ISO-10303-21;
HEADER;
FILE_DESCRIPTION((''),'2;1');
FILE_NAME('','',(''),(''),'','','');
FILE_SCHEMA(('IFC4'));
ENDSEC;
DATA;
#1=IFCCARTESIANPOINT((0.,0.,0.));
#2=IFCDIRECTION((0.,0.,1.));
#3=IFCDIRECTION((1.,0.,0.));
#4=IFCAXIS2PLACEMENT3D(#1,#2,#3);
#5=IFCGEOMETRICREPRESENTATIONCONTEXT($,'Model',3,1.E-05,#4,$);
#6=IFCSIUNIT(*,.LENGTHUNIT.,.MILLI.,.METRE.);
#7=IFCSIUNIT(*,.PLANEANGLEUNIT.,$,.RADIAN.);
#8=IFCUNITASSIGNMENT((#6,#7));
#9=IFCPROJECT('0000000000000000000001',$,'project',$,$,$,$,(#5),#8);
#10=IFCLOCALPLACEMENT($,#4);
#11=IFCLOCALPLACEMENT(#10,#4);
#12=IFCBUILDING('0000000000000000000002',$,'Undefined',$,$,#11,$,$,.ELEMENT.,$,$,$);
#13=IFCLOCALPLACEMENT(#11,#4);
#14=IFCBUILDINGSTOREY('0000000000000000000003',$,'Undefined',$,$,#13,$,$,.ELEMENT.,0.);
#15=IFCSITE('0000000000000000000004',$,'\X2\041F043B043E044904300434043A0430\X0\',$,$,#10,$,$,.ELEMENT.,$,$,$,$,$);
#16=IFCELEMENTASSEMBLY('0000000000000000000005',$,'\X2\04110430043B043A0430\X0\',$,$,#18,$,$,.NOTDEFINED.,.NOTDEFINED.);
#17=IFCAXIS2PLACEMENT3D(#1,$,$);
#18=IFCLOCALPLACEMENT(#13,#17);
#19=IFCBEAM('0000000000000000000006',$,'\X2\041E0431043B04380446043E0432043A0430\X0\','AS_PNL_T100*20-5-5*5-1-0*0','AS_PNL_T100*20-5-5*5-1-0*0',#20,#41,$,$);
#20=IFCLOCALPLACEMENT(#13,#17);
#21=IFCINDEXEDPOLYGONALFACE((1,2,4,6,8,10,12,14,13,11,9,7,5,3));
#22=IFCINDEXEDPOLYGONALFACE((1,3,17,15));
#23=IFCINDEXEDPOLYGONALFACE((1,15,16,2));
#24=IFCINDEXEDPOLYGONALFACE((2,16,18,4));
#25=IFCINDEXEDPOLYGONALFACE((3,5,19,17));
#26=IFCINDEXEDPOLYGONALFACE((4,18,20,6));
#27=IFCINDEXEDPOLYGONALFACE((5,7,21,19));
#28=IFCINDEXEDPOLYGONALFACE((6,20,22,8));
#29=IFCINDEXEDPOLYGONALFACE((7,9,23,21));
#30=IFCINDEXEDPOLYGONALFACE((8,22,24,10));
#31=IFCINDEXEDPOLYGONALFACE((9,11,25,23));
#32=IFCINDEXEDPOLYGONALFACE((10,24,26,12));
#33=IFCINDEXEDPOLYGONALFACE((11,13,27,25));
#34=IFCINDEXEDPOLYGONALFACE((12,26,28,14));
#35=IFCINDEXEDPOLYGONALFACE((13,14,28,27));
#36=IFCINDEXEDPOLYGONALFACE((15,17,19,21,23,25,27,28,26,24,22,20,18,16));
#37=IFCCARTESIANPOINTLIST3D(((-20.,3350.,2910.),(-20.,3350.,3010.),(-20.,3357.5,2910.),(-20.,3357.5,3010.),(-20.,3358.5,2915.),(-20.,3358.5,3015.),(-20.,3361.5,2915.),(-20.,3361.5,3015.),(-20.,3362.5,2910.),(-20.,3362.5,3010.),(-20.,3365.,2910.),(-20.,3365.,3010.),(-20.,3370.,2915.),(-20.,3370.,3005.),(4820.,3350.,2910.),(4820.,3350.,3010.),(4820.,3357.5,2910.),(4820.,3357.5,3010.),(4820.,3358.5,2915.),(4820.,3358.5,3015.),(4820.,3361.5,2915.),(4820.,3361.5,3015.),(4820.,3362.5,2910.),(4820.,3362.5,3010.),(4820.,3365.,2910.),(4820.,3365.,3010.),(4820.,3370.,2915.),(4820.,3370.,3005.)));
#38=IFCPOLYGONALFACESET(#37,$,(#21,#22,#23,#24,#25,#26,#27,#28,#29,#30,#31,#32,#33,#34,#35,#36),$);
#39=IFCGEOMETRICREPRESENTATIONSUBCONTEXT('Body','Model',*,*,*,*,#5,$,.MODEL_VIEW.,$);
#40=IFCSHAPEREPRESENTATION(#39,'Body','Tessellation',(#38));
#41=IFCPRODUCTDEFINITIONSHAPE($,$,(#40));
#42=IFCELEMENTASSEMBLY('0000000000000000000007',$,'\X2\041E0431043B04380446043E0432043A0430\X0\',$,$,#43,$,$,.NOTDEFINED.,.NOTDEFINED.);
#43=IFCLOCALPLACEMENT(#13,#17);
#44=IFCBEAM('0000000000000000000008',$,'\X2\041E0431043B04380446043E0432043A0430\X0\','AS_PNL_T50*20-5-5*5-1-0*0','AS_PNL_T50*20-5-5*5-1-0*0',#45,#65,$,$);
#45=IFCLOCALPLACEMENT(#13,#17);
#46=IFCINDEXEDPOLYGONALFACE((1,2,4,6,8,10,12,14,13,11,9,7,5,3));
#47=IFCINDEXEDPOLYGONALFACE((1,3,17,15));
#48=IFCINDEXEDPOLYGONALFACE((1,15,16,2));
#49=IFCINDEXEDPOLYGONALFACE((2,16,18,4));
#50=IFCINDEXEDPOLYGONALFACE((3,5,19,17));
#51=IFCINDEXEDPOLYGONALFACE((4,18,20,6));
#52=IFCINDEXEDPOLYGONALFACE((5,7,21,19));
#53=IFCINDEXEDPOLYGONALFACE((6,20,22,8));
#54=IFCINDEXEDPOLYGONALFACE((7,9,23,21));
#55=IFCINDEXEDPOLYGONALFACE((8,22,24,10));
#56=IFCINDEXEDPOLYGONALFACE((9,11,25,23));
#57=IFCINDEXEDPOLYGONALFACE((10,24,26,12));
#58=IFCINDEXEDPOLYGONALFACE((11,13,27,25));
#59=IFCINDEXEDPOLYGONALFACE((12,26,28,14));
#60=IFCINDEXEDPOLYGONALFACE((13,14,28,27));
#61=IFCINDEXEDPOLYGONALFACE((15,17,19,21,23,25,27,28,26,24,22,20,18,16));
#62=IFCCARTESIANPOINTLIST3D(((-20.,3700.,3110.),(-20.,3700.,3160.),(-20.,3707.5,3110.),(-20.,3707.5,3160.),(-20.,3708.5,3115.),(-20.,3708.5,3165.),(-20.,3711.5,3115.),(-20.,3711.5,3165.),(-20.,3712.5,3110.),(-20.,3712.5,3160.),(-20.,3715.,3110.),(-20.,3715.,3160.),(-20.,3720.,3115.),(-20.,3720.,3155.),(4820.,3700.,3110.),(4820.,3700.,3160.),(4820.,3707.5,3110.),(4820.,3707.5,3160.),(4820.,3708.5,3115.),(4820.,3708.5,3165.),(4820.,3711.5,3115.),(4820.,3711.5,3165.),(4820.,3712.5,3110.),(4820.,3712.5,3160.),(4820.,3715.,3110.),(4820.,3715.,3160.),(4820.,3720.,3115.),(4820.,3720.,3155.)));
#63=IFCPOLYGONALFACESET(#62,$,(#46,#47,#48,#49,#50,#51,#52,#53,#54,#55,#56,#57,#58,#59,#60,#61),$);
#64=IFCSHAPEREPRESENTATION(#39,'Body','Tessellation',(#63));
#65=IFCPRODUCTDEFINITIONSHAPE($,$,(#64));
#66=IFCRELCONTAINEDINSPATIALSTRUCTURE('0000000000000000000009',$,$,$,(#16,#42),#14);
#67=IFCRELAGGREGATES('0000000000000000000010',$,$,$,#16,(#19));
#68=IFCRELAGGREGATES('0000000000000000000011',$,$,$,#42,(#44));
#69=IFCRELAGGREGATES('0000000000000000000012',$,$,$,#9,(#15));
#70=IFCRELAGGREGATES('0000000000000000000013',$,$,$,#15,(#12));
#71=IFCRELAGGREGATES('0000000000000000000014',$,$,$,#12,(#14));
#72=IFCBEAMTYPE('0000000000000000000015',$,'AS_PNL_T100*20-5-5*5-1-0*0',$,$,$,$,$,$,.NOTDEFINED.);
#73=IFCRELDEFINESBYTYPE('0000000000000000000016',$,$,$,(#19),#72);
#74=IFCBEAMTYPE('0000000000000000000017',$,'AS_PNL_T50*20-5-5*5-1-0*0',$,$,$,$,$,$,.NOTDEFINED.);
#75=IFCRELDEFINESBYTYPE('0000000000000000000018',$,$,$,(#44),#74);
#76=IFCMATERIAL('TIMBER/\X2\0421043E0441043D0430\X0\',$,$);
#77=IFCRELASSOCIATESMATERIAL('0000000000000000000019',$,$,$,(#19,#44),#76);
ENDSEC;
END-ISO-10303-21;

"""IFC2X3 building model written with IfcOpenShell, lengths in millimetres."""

from ifc_helpers import new_model, si_unit, frame, origin_with_axes, place, context, subcontext, project, spatial, polyline, outline, extrude, material, type_object, element, aggregate, save


model = new_model("IFC2X3")

# Units and contexts
model_context = context("Model", 3, precision=1e-05, world=origin_with_axes())
body_context = subcontext(model_context, "Body", "Model", "MODEL_VIEW")
ifc_project = project(units=[si_unit("LENGTHUNIT", "METRE", prefix="MILLI"), si_unit("PLANEANGLEUNIT", "RADIAN")], contexts=[model_context])

# Site, building, storey
site_placement = place(None, origin_with_axes())
site = spatial("IfcSite", under=ifc_project, at=site_placement, Name="Площадка", CompositionType="ELEMENT")
building_placement = place(site_placement, origin_with_axes())
building = spatial("IfcBuilding", under=site, at=building_placement, Name="Undefined", CompositionType="ELEMENT")
storey_placement = place(building_placement, origin_with_axes())
storey = spatial("IfcBuildingStorey", under=building, at=storey_placement, Name="Undefined", CompositionType="ELEMENT", Elevation=0.0)

# Shared definitions
ifc_material = material(Name="TIMBER/Сосна")

# Element assemblies, beams
beam_type_1 = type_object("IfcBeamType", Name="AS_PNL_T100*20-5-5*5-1-0*0", PredefinedType="NOTDEFINED")
assembly_1_placement = place(storey_placement, origin_with_axes())
assembly_1 = element("IfcElementAssembly", 1, at=assembly_1_placement, inside=storey, Name="Балка", AssemblyPlace="NOTDEFINED", PredefinedType="NOTDEFINED")
beam_1_placement = place(assembly_1_placement, frame((4820.0, 3360.0, 2960.0), z_axis=(0.0, 0.0, 1.0), x_axis=(-1.0, 0.0, 0.0)))
beam_1 = element("IfcBeam", 2, at=beam_1_placement, type_object=beam_type_1, material=ifc_material, Name="Облицовка", Description="AS_PNL_T100*20-5-5*5-1-0*0", ObjectType="AS_PNL_T100*20-5-5*5-1-0*0", context=body_context, shape_type="SweptSolid", body=[
    extrude(outline(polyline([(-2.5, -50.0), (-10.0, -50.0), (-10.0, 50.0), (-2.5, 50.0), (-1.5, 55.0), (1.5, 55.0), (2.5, 50.0), (5.0, 50.0), (10.0, 45.0), (10.0, -45.0), (5.0, -50.0), (2.5, -50.0), (1.5, -45.0), (-1.5, -45.0), (-2.5, -50.0)])), frame((4840.0, 0.0, 0.0), z_axis=(-1.0, 0.0, 0.0), x_axis=(0.0, -1.0, 0.0)), (0.0, 0.0, 1.0), 4840.0),
])
aggregate(assembly_1, [beam_1])
assembly_2_placement = place(storey_placement, origin_with_axes())
assembly_2 = element("IfcElementAssembly", 3, at=assembly_2_placement, inside=storey, Name="Облицовка", AssemblyPlace="NOTDEFINED", PredefinedType="NOTDEFINED")
beam_type_2 = type_object("IfcBeamType", Name="AS_PNL_T50*20-5-5*5-1-0*0", PredefinedType="NOTDEFINED")
beam_2_placement = place(assembly_2_placement, frame((4820.0, 3710.0, 3135.0), z_axis=(0.0, 0.0, 1.0), x_axis=(-1.0, 0.0, 0.0)))
beam_2 = element("IfcBeam", 4, at=beam_2_placement, type_object=beam_type_2, material=ifc_material, Name="Облицовка", Description="AS_PNL_T50*20-5-5*5-1-0*0", ObjectType="AS_PNL_T50*20-5-5*5-1-0*0", context=body_context, shape_type="SweptSolid", body=[
    extrude(outline(polyline([(2.5, 25.0), (5.0, 25.0), (10.0, 20.0), (10.0, -20.0), (5.0, -25.0), (2.5, -25.0), (1.5, -20.0), (-1.5, -20.0), (-2.5, -25.0), (-10.0, -25.0), (-10.0, 25.0), (-2.5, 25.0), (-1.5, 30.0), (1.5, 30.0), (2.5, 25.0)])), frame((4840.0, 0.0, 0.0), z_axis=(-1.0, 0.0, 0.0), x_axis=(0.0, -1.0, 0.0)), (0.0, 0.0, 1.0), 4840.0),
])
aggregate(assembly_2, [beam_2])

save(model, "model.ifc")
